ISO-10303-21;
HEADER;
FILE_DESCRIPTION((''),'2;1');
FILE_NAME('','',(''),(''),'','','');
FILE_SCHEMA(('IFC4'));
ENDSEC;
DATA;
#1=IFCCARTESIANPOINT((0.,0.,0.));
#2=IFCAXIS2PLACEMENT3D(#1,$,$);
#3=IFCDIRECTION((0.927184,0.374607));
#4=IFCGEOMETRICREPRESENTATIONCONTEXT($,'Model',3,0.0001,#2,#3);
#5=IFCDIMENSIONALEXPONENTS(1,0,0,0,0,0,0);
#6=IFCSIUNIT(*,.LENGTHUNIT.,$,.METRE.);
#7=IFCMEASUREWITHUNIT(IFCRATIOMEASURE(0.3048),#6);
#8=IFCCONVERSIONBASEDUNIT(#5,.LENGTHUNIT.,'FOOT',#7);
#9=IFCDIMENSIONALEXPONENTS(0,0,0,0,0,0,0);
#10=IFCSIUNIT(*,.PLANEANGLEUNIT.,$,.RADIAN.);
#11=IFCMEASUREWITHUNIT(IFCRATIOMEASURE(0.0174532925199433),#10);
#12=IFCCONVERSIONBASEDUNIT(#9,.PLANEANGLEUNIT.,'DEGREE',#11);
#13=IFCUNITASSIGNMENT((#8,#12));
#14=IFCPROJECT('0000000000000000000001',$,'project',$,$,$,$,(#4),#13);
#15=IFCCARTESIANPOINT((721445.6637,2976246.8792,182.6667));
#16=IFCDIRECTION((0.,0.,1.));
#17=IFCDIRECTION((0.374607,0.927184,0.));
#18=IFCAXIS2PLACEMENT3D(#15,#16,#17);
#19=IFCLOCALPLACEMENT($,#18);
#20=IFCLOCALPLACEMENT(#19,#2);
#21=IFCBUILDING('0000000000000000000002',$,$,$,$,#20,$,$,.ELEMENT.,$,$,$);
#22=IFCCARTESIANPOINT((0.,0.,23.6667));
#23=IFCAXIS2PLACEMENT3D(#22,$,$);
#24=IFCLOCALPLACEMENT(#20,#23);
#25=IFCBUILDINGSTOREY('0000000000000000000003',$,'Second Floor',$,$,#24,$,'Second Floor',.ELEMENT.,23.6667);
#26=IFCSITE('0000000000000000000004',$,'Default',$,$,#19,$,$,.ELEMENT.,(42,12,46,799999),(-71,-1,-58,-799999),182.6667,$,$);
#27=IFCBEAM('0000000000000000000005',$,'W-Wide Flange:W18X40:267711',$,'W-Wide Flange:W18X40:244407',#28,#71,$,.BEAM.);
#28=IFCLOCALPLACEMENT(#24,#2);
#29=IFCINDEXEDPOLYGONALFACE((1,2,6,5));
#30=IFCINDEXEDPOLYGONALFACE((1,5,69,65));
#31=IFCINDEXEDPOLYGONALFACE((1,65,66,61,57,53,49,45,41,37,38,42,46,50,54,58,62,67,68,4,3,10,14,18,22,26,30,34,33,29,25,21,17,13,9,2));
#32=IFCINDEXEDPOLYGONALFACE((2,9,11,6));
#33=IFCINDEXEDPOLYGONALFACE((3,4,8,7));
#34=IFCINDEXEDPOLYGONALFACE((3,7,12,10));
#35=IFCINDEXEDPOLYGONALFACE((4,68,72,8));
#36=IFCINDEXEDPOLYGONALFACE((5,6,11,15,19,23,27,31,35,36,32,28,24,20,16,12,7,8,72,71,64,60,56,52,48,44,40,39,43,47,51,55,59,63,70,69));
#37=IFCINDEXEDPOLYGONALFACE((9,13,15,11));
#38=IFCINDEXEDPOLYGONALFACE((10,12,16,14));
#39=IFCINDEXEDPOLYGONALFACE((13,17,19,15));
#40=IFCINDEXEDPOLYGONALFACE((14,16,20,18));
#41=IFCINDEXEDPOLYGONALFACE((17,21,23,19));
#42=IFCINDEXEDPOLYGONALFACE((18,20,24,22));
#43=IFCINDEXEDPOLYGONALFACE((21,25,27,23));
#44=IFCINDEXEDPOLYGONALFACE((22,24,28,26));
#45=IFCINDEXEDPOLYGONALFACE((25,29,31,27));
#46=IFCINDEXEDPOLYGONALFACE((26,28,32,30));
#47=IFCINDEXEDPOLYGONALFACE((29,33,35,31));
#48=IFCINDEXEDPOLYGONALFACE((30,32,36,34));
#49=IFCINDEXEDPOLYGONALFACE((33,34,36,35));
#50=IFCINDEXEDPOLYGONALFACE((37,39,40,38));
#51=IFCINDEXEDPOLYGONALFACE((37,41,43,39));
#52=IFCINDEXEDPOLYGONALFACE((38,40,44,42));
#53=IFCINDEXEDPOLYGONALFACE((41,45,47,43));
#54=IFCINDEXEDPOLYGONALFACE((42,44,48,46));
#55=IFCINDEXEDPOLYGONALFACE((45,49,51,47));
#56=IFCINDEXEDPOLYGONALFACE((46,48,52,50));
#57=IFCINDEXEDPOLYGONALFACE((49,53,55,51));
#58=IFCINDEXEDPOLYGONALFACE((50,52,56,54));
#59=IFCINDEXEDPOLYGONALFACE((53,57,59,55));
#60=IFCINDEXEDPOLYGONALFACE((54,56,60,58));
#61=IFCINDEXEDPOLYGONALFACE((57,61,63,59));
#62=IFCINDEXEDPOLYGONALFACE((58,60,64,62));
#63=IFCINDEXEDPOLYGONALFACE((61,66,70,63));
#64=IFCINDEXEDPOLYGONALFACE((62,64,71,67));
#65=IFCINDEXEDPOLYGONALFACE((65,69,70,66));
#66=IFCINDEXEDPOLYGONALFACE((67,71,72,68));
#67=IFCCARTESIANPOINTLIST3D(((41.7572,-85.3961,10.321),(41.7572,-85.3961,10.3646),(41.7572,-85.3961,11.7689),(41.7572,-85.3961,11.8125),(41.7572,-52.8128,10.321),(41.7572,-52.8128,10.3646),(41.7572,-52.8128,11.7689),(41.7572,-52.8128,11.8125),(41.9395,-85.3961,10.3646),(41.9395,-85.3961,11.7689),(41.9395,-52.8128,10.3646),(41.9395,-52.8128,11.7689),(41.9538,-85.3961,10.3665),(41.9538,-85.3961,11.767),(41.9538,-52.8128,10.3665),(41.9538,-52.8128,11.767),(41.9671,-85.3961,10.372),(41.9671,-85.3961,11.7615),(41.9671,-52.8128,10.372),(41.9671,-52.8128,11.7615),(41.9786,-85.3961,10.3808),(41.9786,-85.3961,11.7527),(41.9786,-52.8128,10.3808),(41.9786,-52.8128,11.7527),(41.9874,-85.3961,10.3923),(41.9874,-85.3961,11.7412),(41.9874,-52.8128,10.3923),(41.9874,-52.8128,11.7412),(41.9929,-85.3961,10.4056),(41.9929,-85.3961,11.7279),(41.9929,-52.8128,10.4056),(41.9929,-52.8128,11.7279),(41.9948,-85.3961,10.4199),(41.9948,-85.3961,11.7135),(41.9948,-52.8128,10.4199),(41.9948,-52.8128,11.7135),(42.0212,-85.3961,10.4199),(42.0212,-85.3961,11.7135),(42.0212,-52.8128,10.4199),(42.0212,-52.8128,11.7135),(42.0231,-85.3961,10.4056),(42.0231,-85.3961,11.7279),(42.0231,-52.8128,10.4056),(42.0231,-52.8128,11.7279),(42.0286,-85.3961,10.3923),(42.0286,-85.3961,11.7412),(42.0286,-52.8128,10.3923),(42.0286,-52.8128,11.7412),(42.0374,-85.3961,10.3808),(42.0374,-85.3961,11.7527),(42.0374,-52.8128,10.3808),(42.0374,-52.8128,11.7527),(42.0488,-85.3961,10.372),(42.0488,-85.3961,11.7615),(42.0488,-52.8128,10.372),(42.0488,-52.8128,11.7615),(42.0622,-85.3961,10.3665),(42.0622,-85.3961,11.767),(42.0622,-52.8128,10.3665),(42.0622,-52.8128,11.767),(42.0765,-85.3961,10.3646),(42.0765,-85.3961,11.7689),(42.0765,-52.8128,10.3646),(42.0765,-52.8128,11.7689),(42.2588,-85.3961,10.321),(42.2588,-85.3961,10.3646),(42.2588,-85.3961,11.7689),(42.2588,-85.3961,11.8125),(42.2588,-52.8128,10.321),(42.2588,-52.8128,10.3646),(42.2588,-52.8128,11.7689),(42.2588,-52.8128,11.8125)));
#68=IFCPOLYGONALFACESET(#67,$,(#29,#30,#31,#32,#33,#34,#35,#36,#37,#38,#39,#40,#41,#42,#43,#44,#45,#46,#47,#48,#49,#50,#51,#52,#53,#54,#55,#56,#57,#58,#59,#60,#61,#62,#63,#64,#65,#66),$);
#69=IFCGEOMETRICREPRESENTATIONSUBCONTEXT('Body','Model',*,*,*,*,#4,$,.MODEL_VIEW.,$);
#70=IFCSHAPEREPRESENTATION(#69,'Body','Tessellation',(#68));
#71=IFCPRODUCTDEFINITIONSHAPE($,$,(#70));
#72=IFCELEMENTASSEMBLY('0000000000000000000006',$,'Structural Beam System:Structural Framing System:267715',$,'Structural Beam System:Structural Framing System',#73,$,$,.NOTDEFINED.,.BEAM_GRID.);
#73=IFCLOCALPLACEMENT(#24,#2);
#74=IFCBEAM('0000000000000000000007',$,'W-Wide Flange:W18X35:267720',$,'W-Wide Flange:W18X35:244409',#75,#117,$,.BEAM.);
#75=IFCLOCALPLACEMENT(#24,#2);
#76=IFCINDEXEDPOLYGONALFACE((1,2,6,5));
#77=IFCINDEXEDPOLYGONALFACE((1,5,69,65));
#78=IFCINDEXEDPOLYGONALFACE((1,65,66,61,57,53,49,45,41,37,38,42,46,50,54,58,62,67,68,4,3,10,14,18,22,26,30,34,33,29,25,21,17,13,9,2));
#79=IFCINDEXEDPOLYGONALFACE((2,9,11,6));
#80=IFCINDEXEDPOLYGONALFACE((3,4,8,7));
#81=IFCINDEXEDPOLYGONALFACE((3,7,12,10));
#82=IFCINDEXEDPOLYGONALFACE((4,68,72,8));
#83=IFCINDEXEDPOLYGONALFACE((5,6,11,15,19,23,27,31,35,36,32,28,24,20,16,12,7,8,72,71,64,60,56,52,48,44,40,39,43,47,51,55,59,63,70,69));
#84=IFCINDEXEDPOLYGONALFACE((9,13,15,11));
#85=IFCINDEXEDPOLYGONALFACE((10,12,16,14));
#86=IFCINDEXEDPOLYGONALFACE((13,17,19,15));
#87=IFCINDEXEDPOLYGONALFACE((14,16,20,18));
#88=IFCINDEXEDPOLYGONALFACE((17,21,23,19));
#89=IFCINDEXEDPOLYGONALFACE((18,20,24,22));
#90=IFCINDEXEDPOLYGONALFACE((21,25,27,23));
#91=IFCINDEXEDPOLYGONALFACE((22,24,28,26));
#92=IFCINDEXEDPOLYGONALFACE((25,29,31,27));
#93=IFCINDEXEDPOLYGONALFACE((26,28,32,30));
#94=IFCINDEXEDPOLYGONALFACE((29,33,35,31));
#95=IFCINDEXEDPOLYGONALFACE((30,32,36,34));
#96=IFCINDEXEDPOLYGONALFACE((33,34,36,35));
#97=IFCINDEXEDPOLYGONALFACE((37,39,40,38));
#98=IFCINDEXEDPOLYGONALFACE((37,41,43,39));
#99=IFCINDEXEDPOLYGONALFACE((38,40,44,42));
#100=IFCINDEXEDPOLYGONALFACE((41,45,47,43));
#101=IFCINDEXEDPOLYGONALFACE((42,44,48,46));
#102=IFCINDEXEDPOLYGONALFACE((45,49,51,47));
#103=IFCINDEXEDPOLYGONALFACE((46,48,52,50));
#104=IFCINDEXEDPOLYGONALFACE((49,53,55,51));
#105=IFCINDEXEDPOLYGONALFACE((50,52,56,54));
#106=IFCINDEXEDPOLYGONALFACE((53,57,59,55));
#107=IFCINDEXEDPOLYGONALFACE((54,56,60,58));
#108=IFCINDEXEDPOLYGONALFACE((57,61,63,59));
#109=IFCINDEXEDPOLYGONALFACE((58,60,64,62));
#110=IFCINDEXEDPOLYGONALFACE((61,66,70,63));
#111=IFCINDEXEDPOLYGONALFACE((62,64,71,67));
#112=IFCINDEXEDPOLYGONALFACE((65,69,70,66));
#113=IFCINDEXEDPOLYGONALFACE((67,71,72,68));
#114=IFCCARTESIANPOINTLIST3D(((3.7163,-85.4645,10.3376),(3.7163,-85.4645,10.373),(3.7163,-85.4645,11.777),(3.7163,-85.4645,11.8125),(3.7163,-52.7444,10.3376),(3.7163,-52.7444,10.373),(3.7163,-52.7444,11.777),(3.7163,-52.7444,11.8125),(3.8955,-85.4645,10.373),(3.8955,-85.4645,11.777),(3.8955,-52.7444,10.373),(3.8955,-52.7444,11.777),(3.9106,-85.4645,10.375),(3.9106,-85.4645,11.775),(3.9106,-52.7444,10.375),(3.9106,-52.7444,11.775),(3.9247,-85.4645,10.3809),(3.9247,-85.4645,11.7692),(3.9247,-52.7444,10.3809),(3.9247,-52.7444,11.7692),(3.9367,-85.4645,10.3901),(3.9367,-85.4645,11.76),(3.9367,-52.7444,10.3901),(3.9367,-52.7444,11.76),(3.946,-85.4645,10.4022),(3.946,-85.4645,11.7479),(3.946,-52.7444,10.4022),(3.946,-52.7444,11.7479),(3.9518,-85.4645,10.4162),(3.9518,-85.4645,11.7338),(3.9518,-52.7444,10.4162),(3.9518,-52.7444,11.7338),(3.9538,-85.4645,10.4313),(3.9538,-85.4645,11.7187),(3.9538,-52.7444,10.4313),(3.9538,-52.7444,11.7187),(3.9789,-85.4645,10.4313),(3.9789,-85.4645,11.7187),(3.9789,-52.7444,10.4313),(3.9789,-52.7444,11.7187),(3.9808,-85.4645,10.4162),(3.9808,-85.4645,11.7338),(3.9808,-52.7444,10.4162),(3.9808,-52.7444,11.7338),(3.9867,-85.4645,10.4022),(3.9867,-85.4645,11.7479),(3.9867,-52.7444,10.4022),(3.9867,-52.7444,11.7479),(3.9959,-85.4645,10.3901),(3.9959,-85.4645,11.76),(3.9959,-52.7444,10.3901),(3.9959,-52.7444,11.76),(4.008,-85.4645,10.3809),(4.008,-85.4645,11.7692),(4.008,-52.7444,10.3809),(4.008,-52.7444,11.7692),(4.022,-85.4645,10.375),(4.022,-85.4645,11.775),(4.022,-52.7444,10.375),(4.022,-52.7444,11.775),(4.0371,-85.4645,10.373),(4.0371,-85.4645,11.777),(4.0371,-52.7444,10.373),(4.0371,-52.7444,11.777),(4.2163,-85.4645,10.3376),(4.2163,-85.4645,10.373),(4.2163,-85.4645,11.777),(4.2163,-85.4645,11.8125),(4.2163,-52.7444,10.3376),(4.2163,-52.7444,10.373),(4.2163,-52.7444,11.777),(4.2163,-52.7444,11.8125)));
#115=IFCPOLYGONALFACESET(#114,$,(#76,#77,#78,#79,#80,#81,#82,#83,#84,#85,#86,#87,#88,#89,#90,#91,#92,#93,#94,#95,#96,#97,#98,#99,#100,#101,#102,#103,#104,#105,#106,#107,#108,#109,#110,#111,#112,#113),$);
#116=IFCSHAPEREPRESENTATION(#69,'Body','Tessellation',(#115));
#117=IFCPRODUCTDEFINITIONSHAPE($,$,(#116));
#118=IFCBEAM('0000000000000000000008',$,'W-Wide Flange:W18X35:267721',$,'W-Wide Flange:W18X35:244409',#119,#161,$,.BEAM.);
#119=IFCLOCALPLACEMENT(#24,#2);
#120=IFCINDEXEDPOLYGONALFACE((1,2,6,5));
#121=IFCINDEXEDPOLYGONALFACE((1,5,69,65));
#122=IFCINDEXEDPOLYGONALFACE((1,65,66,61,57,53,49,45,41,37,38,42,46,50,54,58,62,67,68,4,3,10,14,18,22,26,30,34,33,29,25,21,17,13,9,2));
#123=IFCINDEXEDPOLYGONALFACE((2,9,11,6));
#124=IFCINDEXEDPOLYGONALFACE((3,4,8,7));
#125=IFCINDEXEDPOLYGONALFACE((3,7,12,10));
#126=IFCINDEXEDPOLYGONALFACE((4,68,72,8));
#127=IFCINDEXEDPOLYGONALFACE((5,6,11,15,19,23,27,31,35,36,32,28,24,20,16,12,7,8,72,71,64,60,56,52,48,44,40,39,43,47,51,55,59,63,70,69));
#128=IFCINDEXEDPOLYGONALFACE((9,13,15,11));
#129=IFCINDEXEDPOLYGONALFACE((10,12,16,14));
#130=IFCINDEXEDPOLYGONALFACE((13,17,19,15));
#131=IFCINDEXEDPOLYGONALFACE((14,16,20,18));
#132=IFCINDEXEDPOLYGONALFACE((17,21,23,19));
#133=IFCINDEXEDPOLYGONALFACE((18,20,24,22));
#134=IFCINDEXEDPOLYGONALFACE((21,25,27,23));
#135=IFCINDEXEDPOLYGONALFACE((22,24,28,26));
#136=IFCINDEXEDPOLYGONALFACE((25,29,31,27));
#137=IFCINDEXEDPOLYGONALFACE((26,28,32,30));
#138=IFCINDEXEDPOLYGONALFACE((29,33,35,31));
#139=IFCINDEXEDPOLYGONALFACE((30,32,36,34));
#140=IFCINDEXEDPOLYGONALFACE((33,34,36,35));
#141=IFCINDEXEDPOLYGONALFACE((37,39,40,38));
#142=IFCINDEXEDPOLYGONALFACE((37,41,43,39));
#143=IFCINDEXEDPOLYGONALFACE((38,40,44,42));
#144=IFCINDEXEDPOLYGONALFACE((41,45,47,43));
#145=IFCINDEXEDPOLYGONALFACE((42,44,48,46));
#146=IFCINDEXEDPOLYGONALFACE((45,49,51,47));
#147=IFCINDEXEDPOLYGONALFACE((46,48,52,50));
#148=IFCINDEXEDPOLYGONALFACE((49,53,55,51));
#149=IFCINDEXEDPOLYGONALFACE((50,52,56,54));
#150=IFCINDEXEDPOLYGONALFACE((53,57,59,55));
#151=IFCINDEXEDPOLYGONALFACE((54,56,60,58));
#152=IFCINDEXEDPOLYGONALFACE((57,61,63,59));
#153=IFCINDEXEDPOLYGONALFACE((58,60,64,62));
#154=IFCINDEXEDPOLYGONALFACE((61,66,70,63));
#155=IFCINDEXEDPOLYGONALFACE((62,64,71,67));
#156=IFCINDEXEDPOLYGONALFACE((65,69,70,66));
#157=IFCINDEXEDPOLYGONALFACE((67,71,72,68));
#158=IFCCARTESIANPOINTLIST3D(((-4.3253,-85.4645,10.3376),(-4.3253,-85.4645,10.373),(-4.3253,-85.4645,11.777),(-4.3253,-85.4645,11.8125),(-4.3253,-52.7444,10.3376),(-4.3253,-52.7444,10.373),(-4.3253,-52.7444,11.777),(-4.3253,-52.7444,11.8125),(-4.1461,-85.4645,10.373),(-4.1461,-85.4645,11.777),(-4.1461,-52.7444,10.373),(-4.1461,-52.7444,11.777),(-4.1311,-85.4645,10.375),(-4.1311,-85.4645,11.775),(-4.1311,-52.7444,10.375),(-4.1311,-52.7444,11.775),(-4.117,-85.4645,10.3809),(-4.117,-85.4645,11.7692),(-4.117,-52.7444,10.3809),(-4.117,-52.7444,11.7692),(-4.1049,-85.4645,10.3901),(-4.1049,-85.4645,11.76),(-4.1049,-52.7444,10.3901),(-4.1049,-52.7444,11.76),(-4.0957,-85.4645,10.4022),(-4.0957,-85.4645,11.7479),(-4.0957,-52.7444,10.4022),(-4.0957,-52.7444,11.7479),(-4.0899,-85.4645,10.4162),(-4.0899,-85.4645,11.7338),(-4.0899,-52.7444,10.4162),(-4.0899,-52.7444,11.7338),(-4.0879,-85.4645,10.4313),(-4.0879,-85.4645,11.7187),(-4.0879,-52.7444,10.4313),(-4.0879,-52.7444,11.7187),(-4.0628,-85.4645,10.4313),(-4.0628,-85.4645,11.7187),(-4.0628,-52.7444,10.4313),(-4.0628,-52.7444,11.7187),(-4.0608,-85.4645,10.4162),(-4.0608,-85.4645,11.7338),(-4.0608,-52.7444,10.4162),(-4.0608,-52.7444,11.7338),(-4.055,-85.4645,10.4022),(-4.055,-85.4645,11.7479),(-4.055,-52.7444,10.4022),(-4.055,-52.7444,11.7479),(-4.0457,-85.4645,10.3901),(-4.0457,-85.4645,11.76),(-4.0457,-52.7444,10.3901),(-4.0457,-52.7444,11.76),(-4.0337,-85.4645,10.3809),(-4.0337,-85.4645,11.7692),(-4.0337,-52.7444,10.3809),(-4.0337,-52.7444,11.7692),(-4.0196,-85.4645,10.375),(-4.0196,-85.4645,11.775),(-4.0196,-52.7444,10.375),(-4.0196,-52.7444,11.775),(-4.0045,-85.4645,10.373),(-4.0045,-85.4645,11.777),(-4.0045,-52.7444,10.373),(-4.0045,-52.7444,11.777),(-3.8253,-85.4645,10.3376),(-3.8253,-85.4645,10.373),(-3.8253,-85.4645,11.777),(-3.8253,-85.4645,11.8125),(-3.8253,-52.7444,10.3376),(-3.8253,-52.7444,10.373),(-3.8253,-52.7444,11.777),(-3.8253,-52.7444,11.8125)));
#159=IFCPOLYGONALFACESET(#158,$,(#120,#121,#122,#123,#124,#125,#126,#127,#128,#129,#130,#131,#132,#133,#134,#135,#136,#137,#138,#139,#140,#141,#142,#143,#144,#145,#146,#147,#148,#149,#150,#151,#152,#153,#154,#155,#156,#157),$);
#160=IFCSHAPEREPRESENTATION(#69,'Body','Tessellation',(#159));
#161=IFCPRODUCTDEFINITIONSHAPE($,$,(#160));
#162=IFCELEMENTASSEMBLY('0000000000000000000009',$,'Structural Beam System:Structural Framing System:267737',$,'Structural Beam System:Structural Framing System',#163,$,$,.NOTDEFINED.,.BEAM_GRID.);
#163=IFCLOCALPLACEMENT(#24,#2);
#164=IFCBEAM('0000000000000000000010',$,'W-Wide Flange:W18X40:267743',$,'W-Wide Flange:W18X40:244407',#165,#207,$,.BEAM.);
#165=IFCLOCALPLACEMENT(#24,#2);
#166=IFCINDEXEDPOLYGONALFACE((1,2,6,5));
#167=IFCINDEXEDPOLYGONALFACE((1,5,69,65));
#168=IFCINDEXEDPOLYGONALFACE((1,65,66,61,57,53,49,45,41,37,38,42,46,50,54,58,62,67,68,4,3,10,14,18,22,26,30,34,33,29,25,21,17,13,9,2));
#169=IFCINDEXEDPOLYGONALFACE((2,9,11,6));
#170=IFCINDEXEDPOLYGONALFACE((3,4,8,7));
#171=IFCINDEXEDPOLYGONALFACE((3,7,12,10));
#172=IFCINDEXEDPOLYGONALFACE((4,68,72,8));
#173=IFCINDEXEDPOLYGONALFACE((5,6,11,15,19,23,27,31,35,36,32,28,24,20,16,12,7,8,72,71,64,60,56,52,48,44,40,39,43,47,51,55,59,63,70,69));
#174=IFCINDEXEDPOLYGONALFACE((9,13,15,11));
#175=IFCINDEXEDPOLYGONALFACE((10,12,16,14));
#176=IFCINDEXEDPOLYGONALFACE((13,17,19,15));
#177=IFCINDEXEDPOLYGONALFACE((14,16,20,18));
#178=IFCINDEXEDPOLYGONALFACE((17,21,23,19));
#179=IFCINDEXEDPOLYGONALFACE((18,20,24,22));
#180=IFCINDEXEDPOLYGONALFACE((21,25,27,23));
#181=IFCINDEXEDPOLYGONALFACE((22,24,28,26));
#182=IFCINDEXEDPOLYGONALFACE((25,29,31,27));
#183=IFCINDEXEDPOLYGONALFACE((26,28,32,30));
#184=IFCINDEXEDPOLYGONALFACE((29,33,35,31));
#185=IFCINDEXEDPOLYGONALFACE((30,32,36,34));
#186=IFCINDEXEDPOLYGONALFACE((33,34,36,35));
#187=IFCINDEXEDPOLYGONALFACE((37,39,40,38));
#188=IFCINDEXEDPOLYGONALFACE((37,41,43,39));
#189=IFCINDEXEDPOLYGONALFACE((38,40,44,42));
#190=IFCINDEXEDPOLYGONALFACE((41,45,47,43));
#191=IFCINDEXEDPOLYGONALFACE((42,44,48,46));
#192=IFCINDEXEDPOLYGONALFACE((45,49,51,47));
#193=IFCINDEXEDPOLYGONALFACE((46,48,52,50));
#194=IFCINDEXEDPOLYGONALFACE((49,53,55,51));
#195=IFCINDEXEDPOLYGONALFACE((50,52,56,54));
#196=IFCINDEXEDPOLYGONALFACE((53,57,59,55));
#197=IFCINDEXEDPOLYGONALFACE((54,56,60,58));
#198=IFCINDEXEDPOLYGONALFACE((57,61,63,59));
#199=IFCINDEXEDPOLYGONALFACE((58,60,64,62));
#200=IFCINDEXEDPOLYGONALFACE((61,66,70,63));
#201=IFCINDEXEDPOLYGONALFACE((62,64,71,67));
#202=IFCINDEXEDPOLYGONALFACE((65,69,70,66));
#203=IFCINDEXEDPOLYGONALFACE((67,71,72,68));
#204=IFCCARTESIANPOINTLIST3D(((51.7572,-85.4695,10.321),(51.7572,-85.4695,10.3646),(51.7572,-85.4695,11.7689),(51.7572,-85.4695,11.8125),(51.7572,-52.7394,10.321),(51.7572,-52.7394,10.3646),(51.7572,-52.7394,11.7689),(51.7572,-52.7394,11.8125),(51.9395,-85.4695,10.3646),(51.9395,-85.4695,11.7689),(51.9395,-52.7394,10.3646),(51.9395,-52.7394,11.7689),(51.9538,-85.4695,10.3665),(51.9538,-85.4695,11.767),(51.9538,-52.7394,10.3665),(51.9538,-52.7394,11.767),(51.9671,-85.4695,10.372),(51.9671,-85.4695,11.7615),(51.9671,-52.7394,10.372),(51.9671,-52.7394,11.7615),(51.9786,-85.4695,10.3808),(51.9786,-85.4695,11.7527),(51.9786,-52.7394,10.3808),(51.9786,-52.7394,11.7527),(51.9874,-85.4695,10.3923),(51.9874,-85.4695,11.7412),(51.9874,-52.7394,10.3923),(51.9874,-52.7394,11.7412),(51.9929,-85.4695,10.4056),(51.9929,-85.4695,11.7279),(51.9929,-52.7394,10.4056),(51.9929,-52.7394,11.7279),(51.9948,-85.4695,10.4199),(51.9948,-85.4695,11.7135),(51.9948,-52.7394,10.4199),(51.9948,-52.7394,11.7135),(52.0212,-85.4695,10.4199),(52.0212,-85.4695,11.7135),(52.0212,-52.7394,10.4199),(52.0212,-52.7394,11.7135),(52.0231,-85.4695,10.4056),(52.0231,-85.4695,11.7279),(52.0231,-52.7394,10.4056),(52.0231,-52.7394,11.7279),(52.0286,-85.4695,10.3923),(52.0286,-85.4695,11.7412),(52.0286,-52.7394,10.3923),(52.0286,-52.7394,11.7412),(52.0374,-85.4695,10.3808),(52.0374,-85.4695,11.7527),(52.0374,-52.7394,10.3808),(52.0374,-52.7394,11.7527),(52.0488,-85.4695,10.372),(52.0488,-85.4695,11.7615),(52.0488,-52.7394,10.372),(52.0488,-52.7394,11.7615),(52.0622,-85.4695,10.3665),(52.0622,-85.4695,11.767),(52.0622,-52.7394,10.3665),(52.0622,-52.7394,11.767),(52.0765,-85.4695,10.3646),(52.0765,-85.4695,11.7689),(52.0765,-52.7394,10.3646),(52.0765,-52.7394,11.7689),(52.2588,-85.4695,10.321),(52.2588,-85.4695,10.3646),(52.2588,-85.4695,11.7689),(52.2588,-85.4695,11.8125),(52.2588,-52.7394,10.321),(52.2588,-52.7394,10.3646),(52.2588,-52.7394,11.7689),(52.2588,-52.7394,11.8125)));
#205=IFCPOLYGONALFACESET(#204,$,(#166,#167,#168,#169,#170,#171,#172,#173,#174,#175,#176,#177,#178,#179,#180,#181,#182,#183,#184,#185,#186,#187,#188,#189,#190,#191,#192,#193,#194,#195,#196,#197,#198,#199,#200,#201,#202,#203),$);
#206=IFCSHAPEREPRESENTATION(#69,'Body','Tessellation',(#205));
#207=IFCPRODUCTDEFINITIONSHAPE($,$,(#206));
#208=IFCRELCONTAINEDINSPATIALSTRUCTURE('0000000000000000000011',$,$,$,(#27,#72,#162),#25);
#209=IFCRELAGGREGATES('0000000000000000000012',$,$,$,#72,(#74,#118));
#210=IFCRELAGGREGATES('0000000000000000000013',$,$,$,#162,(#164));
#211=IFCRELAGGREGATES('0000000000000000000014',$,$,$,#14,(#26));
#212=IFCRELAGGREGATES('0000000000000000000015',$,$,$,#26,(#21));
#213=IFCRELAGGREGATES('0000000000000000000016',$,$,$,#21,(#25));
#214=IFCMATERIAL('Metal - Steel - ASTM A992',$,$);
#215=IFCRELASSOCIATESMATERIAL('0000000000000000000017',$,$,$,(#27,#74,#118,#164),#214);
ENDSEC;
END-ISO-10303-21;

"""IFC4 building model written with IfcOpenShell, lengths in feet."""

from ifc_helpers import new_model, entity, si_unit, converted_unit, direction, frame, frame_2d, origin, place, context, subcontext, project, spatial, i_section, extrude, material, element, aggregate, save


model = new_model("IFC4")

# Units and contexts
model_context = context("Model", 3, precision=0.0001, world=origin(), true_north=direction((0.927184, 0.374607)))
body_context = subcontext(model_context, "Body", "Model", "MODEL_VIEW")
ifc_project = project(units=[converted_unit("LENGTHUNIT", "FOOT", entity("IfcRatioMeasure", 0.3048), si_unit("LENGTHUNIT", "METRE"), dimensions=[1, 0, 0, 0, 0, 0, 0]), converted_unit("PLANEANGLEUNIT", "DEGREE", entity("IfcRatioMeasure", 0.0174532925199433), si_unit("PLANEANGLEUNIT", "RADIAN"), dimensions=[0, 0, 0, 0, 0, 0, 0])], contexts=[model_context])

# Site, building, storey
site_placement = place(None, frame((721445.6637, 2976246.8792, 182.6667), z_axis=(0.0, 0.0, 1.0), x_axis=(0.374607, 0.927184, 0.0)))
site = spatial("IfcSite", under=ifc_project, at=site_placement, Name="Default", CompositionType="ELEMENT", RefLatitude=(42, 12, 46, 799999), RefLongitude=(-71, -1, -58, -799999), RefElevation=182.6667)
building_placement = place(site_placement, origin())
building = spatial("IfcBuilding", under=site, at=building_placement, CompositionType="ELEMENT")
storey_placement = place(building_placement, frame((0.0, 0.0, 23.6667)))
storey = spatial("IfcBuildingStorey", under=building, at=storey_placement, Name="Second Floor", LongName="Second Floor", CompositionType="ELEMENT", Elevation=23.6667)

# Shared definitions
ifc_material_1 = material(Name="Metal - Steel - ASTM A992")

# Beam
beam_1_placement = place(storey_placement, frame((42.008, -52.3544, 11.8125), z_axis=(0.0, 0.0, 1.0), x_axis=(0.0, -1.0, 0.0)))
element("IfcBeam", 1, at=beam_1_placement, inside=storey, material=ifc_material_1, Name="W-Wide Flange:W18X40:267711", ObjectType="W-Wide Flange:W18X40:244407", PredefinedType="BEAM", context=body_context, shape_type="SweptSolid", body=[
    extrude(i_section(OverallWidth=0.5016, OverallDepth=1.4915, WebThickness=0.0264, FlangeThickness=0.0436, FilletRadius=0.0553, at=frame_2d((0.0, 0.0), x_axis=(0.0, 1.0))), frame((0.4583, 0.0, -0.7458), z_axis=(1.0, 0.0, 0.0), x_axis=(0.0, 0.0, -1.0)), (0.0, 0.0, 1.0), 32.5833),
])

# Element assembly, beams
assembly_1_placement = place(storey_placement, origin())
assembly_1 = element("IfcElementAssembly", 2, at=assembly_1_placement, inside=storey, Name="Structural Beam System:Structural Framing System:267715", ObjectType="Structural Beam System:Structural Framing System", AssemblyPlace="NOTDEFINED", PredefinedType="BEAM_GRID")
beam_2_placement = place(assembly_1_placement, frame((3.9663, -52.3544, 11.8125), z_axis=(0.0, 0.0, 1.0), x_axis=(0.0, -1.0, 0.0)))
beam_2 = element("IfcBeam", 3, at=beam_2_placement, material=ifc_material_1, Name="W-Wide Flange:W18X35:267720", ObjectType="W-Wide Flange:W18X35:244409", PredefinedType="BEAM", context=body_context, shape_type="SweptSolid", body=[
    extrude(i_section(OverallWidth=0.5, OverallDepth=1.4749, WebThickness=0.0251, FlangeThickness=0.0355, FilletRadius=0.0583, at=frame_2d((0.0, 0.0), x_axis=(0.0, 1.0))), frame((0.39, 0.0, -0.7375), z_axis=(1.0, 0.0, 0.0), x_axis=(0.0, 0.0, -1.0)), (0.0, 0.0, 1.0), 32.7201),
])
beam_3_placement = place(assembly_1_placement, frame((-4.0753, -52.3544, 11.8125), z_axis=(0.0, 0.0, 1.0), x_axis=(0.0, -1.0, 0.0)))
beam_3 = element("IfcBeam", 4, at=beam_3_placement, material=ifc_material_1, Name="W-Wide Flange:W18X35:267721", ObjectType="W-Wide Flange:W18X35:244409", PredefinedType="BEAM", context=body_context, shape_type="SweptSolid", body=[
    extrude(i_section(OverallWidth=0.5, OverallDepth=1.4749, WebThickness=0.0251, FlangeThickness=0.0355, FilletRadius=0.0583, at=frame_2d((0.0, 0.0), x_axis=(0.0, 1.0))), frame((0.39, 0.0, -0.7375), z_axis=(1.0, 0.0, 0.0), x_axis=(0.0, 0.0, -1.0)), (0.0, 0.0, 1.0), 32.7201),
])
aggregate(assembly_1, [beam_2, beam_3])

# Element assembly, beam
assembly_2_placement = place(storey_placement, origin())
assembly_2 = element("IfcElementAssembly", 5, at=assembly_2_placement, inside=storey, Name="Structural Beam System:Structural Framing System:267737", ObjectType="Structural Beam System:Structural Framing System", AssemblyPlace="NOTDEFINED", PredefinedType="BEAM_GRID")
beam_4_placement = place(assembly_2_placement, frame((52.008, -52.3544, 11.8125), z_axis=(0.0, 0.0, 1.0), x_axis=(0.0, -1.0, 0.0)))
beam_4 = element("IfcBeam", 6, at=beam_4_placement, material=ifc_material_1, Name="W-Wide Flange:W18X40:267743", ObjectType="W-Wide Flange:W18X40:244407", PredefinedType="BEAM", context=body_context, shape_type="SweptSolid", body=[
    extrude(i_section(OverallWidth=0.5016, OverallDepth=1.4915, WebThickness=0.0264, FlangeThickness=0.0436, FilletRadius=0.0553, at=frame_2d((0.0, 0.0), x_axis=(0.0, 1.0))), frame((0.3849, 0.0, -0.7458), z_axis=(1.0, 0.0, 0.0), x_axis=(0.0, 0.0, -1.0)), (0.0, 0.0, 1.0), 32.7301),
])
aggregate(assembly_2, [beam_4])

save(model, "model.ifc")
